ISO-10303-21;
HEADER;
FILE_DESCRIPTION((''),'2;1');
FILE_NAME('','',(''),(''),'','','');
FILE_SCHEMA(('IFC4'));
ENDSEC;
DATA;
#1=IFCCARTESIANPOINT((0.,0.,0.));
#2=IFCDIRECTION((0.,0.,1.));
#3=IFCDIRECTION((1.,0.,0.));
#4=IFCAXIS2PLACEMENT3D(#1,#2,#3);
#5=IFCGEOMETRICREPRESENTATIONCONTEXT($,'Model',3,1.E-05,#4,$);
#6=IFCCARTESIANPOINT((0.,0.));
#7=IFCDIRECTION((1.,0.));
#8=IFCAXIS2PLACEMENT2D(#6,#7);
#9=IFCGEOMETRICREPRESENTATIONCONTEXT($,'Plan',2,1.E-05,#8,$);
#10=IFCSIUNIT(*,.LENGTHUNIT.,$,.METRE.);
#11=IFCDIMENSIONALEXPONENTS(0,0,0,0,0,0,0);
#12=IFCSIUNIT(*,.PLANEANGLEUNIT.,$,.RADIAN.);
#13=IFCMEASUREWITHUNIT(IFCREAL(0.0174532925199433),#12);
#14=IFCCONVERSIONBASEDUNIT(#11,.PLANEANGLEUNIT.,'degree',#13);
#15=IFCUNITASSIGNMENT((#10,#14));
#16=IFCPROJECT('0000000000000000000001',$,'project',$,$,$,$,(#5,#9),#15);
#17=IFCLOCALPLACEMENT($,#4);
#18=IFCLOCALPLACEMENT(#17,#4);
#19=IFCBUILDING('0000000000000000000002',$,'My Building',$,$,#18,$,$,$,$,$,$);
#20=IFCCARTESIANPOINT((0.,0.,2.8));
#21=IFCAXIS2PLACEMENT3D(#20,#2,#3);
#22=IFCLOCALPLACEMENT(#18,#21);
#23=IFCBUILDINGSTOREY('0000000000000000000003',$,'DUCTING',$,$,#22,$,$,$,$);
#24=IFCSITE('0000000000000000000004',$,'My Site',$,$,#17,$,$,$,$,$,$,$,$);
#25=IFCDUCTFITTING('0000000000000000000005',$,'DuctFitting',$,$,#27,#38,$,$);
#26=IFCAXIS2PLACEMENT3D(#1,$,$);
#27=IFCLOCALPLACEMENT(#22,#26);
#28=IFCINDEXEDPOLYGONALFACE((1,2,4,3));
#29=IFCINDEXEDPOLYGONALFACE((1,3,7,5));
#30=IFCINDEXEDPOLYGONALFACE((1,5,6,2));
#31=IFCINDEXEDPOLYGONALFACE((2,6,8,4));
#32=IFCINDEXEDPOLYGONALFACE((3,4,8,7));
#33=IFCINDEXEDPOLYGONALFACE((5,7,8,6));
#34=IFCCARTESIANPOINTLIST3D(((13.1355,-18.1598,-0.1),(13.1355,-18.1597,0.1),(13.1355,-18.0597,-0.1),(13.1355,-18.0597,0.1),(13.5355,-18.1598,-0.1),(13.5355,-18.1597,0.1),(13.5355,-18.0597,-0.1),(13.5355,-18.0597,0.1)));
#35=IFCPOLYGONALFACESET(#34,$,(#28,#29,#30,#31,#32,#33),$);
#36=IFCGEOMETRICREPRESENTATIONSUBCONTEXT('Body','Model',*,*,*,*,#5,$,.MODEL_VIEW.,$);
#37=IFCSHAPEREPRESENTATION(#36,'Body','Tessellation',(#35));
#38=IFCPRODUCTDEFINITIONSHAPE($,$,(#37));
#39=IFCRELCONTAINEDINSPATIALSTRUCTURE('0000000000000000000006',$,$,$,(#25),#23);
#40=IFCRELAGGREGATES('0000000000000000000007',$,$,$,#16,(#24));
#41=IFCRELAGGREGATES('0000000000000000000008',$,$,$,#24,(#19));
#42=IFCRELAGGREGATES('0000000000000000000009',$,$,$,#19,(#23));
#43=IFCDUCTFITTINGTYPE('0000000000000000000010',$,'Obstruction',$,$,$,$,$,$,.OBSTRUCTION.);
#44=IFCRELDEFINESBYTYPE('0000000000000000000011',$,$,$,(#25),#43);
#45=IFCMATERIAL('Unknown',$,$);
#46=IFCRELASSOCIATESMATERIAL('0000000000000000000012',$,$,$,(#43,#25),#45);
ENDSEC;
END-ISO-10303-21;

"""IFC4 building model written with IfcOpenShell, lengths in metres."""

from ifc_helpers import new_model, entity, si_unit, converted_unit, frame, origin_with_axes, origin_2d_with_axis, place, context, subcontext, project, spatial, rectangle, extrude, material, material_profile, profile_set, profile_usage, type_object, element, save


model = new_model("IFC4")

# Units and contexts
model_context = context("Model", 3, precision=1e-05, world=origin_with_axes())
plan_context = context("Plan", 2, precision=1e-05, world=origin_2d_with_axis())
body_context = subcontext(model_context, "Body", "Model", "MODEL_VIEW")
ifc_project = project(units=[si_unit("LENGTHUNIT", "METRE"), converted_unit("PLANEANGLEUNIT", "degree", entity("IfcReal", 0.0174532925199433), si_unit("PLANEANGLEUNIT", "RADIAN"), dimensions=[0, 0, 0, 0, 0, 0, 0])], contexts=[model_context, plan_context])

# Site, building, storey
site_placement = place(None, origin_with_axes())
site = spatial("IfcSite", under=ifc_project, at=site_placement, Name="My Site")
building_placement = place(site_placement, origin_with_axes())
building = spatial("IfcBuilding", under=site, at=building_placement, Name="My Building")
storey_placement = place(building_placement, frame((0.0, 0.0, 2.8), z_axis=(0.0, 0.0, 1.0), x_axis=(1.0, 0.0, 0.0)))
storey = spatial("IfcBuildingStorey", under=building, at=storey_placement, Name="DUCTING")

# Shared definitions
ifc_material = material(Name="Unknown")

# Duct fitting
ifc_material_profile_1 = material_profile(ifc_material, rectangle(XDim=0.4, YDim=0.2))
ifc_profile_set_1 = profile_set([ifc_material_profile_1])
duct_fitting_type_1 = type_object("IfcDuctFittingType", Name="Obstruction", PredefinedType="OBSTRUCTION", material=ifc_profile_set_1)
ifc_profile_usage_1 = profile_usage(ifc_profile_set_1, cardinal=5)
duct_fitting_1_placement = place(storey_placement, frame((13.3355, -18.0597, 0.0), z_axis=(0.0, -1.0, 0.0), x_axis=(1.0, 0.0, 0.0)))
element("IfcDuctFitting", 1, at=duct_fitting_1_placement, inside=storey, type_object=duct_fitting_type_1, material=ifc_profile_usage_1, Name="DuctFitting", context=body_context, shape_type="SweptSolid", body=[
    extrude(rectangle(XDim=0.4, YDim=0.2), origin_with_axes(), (0.0, 0.0, 1.0), 0.1),
])

save(model, "model.ifc")
